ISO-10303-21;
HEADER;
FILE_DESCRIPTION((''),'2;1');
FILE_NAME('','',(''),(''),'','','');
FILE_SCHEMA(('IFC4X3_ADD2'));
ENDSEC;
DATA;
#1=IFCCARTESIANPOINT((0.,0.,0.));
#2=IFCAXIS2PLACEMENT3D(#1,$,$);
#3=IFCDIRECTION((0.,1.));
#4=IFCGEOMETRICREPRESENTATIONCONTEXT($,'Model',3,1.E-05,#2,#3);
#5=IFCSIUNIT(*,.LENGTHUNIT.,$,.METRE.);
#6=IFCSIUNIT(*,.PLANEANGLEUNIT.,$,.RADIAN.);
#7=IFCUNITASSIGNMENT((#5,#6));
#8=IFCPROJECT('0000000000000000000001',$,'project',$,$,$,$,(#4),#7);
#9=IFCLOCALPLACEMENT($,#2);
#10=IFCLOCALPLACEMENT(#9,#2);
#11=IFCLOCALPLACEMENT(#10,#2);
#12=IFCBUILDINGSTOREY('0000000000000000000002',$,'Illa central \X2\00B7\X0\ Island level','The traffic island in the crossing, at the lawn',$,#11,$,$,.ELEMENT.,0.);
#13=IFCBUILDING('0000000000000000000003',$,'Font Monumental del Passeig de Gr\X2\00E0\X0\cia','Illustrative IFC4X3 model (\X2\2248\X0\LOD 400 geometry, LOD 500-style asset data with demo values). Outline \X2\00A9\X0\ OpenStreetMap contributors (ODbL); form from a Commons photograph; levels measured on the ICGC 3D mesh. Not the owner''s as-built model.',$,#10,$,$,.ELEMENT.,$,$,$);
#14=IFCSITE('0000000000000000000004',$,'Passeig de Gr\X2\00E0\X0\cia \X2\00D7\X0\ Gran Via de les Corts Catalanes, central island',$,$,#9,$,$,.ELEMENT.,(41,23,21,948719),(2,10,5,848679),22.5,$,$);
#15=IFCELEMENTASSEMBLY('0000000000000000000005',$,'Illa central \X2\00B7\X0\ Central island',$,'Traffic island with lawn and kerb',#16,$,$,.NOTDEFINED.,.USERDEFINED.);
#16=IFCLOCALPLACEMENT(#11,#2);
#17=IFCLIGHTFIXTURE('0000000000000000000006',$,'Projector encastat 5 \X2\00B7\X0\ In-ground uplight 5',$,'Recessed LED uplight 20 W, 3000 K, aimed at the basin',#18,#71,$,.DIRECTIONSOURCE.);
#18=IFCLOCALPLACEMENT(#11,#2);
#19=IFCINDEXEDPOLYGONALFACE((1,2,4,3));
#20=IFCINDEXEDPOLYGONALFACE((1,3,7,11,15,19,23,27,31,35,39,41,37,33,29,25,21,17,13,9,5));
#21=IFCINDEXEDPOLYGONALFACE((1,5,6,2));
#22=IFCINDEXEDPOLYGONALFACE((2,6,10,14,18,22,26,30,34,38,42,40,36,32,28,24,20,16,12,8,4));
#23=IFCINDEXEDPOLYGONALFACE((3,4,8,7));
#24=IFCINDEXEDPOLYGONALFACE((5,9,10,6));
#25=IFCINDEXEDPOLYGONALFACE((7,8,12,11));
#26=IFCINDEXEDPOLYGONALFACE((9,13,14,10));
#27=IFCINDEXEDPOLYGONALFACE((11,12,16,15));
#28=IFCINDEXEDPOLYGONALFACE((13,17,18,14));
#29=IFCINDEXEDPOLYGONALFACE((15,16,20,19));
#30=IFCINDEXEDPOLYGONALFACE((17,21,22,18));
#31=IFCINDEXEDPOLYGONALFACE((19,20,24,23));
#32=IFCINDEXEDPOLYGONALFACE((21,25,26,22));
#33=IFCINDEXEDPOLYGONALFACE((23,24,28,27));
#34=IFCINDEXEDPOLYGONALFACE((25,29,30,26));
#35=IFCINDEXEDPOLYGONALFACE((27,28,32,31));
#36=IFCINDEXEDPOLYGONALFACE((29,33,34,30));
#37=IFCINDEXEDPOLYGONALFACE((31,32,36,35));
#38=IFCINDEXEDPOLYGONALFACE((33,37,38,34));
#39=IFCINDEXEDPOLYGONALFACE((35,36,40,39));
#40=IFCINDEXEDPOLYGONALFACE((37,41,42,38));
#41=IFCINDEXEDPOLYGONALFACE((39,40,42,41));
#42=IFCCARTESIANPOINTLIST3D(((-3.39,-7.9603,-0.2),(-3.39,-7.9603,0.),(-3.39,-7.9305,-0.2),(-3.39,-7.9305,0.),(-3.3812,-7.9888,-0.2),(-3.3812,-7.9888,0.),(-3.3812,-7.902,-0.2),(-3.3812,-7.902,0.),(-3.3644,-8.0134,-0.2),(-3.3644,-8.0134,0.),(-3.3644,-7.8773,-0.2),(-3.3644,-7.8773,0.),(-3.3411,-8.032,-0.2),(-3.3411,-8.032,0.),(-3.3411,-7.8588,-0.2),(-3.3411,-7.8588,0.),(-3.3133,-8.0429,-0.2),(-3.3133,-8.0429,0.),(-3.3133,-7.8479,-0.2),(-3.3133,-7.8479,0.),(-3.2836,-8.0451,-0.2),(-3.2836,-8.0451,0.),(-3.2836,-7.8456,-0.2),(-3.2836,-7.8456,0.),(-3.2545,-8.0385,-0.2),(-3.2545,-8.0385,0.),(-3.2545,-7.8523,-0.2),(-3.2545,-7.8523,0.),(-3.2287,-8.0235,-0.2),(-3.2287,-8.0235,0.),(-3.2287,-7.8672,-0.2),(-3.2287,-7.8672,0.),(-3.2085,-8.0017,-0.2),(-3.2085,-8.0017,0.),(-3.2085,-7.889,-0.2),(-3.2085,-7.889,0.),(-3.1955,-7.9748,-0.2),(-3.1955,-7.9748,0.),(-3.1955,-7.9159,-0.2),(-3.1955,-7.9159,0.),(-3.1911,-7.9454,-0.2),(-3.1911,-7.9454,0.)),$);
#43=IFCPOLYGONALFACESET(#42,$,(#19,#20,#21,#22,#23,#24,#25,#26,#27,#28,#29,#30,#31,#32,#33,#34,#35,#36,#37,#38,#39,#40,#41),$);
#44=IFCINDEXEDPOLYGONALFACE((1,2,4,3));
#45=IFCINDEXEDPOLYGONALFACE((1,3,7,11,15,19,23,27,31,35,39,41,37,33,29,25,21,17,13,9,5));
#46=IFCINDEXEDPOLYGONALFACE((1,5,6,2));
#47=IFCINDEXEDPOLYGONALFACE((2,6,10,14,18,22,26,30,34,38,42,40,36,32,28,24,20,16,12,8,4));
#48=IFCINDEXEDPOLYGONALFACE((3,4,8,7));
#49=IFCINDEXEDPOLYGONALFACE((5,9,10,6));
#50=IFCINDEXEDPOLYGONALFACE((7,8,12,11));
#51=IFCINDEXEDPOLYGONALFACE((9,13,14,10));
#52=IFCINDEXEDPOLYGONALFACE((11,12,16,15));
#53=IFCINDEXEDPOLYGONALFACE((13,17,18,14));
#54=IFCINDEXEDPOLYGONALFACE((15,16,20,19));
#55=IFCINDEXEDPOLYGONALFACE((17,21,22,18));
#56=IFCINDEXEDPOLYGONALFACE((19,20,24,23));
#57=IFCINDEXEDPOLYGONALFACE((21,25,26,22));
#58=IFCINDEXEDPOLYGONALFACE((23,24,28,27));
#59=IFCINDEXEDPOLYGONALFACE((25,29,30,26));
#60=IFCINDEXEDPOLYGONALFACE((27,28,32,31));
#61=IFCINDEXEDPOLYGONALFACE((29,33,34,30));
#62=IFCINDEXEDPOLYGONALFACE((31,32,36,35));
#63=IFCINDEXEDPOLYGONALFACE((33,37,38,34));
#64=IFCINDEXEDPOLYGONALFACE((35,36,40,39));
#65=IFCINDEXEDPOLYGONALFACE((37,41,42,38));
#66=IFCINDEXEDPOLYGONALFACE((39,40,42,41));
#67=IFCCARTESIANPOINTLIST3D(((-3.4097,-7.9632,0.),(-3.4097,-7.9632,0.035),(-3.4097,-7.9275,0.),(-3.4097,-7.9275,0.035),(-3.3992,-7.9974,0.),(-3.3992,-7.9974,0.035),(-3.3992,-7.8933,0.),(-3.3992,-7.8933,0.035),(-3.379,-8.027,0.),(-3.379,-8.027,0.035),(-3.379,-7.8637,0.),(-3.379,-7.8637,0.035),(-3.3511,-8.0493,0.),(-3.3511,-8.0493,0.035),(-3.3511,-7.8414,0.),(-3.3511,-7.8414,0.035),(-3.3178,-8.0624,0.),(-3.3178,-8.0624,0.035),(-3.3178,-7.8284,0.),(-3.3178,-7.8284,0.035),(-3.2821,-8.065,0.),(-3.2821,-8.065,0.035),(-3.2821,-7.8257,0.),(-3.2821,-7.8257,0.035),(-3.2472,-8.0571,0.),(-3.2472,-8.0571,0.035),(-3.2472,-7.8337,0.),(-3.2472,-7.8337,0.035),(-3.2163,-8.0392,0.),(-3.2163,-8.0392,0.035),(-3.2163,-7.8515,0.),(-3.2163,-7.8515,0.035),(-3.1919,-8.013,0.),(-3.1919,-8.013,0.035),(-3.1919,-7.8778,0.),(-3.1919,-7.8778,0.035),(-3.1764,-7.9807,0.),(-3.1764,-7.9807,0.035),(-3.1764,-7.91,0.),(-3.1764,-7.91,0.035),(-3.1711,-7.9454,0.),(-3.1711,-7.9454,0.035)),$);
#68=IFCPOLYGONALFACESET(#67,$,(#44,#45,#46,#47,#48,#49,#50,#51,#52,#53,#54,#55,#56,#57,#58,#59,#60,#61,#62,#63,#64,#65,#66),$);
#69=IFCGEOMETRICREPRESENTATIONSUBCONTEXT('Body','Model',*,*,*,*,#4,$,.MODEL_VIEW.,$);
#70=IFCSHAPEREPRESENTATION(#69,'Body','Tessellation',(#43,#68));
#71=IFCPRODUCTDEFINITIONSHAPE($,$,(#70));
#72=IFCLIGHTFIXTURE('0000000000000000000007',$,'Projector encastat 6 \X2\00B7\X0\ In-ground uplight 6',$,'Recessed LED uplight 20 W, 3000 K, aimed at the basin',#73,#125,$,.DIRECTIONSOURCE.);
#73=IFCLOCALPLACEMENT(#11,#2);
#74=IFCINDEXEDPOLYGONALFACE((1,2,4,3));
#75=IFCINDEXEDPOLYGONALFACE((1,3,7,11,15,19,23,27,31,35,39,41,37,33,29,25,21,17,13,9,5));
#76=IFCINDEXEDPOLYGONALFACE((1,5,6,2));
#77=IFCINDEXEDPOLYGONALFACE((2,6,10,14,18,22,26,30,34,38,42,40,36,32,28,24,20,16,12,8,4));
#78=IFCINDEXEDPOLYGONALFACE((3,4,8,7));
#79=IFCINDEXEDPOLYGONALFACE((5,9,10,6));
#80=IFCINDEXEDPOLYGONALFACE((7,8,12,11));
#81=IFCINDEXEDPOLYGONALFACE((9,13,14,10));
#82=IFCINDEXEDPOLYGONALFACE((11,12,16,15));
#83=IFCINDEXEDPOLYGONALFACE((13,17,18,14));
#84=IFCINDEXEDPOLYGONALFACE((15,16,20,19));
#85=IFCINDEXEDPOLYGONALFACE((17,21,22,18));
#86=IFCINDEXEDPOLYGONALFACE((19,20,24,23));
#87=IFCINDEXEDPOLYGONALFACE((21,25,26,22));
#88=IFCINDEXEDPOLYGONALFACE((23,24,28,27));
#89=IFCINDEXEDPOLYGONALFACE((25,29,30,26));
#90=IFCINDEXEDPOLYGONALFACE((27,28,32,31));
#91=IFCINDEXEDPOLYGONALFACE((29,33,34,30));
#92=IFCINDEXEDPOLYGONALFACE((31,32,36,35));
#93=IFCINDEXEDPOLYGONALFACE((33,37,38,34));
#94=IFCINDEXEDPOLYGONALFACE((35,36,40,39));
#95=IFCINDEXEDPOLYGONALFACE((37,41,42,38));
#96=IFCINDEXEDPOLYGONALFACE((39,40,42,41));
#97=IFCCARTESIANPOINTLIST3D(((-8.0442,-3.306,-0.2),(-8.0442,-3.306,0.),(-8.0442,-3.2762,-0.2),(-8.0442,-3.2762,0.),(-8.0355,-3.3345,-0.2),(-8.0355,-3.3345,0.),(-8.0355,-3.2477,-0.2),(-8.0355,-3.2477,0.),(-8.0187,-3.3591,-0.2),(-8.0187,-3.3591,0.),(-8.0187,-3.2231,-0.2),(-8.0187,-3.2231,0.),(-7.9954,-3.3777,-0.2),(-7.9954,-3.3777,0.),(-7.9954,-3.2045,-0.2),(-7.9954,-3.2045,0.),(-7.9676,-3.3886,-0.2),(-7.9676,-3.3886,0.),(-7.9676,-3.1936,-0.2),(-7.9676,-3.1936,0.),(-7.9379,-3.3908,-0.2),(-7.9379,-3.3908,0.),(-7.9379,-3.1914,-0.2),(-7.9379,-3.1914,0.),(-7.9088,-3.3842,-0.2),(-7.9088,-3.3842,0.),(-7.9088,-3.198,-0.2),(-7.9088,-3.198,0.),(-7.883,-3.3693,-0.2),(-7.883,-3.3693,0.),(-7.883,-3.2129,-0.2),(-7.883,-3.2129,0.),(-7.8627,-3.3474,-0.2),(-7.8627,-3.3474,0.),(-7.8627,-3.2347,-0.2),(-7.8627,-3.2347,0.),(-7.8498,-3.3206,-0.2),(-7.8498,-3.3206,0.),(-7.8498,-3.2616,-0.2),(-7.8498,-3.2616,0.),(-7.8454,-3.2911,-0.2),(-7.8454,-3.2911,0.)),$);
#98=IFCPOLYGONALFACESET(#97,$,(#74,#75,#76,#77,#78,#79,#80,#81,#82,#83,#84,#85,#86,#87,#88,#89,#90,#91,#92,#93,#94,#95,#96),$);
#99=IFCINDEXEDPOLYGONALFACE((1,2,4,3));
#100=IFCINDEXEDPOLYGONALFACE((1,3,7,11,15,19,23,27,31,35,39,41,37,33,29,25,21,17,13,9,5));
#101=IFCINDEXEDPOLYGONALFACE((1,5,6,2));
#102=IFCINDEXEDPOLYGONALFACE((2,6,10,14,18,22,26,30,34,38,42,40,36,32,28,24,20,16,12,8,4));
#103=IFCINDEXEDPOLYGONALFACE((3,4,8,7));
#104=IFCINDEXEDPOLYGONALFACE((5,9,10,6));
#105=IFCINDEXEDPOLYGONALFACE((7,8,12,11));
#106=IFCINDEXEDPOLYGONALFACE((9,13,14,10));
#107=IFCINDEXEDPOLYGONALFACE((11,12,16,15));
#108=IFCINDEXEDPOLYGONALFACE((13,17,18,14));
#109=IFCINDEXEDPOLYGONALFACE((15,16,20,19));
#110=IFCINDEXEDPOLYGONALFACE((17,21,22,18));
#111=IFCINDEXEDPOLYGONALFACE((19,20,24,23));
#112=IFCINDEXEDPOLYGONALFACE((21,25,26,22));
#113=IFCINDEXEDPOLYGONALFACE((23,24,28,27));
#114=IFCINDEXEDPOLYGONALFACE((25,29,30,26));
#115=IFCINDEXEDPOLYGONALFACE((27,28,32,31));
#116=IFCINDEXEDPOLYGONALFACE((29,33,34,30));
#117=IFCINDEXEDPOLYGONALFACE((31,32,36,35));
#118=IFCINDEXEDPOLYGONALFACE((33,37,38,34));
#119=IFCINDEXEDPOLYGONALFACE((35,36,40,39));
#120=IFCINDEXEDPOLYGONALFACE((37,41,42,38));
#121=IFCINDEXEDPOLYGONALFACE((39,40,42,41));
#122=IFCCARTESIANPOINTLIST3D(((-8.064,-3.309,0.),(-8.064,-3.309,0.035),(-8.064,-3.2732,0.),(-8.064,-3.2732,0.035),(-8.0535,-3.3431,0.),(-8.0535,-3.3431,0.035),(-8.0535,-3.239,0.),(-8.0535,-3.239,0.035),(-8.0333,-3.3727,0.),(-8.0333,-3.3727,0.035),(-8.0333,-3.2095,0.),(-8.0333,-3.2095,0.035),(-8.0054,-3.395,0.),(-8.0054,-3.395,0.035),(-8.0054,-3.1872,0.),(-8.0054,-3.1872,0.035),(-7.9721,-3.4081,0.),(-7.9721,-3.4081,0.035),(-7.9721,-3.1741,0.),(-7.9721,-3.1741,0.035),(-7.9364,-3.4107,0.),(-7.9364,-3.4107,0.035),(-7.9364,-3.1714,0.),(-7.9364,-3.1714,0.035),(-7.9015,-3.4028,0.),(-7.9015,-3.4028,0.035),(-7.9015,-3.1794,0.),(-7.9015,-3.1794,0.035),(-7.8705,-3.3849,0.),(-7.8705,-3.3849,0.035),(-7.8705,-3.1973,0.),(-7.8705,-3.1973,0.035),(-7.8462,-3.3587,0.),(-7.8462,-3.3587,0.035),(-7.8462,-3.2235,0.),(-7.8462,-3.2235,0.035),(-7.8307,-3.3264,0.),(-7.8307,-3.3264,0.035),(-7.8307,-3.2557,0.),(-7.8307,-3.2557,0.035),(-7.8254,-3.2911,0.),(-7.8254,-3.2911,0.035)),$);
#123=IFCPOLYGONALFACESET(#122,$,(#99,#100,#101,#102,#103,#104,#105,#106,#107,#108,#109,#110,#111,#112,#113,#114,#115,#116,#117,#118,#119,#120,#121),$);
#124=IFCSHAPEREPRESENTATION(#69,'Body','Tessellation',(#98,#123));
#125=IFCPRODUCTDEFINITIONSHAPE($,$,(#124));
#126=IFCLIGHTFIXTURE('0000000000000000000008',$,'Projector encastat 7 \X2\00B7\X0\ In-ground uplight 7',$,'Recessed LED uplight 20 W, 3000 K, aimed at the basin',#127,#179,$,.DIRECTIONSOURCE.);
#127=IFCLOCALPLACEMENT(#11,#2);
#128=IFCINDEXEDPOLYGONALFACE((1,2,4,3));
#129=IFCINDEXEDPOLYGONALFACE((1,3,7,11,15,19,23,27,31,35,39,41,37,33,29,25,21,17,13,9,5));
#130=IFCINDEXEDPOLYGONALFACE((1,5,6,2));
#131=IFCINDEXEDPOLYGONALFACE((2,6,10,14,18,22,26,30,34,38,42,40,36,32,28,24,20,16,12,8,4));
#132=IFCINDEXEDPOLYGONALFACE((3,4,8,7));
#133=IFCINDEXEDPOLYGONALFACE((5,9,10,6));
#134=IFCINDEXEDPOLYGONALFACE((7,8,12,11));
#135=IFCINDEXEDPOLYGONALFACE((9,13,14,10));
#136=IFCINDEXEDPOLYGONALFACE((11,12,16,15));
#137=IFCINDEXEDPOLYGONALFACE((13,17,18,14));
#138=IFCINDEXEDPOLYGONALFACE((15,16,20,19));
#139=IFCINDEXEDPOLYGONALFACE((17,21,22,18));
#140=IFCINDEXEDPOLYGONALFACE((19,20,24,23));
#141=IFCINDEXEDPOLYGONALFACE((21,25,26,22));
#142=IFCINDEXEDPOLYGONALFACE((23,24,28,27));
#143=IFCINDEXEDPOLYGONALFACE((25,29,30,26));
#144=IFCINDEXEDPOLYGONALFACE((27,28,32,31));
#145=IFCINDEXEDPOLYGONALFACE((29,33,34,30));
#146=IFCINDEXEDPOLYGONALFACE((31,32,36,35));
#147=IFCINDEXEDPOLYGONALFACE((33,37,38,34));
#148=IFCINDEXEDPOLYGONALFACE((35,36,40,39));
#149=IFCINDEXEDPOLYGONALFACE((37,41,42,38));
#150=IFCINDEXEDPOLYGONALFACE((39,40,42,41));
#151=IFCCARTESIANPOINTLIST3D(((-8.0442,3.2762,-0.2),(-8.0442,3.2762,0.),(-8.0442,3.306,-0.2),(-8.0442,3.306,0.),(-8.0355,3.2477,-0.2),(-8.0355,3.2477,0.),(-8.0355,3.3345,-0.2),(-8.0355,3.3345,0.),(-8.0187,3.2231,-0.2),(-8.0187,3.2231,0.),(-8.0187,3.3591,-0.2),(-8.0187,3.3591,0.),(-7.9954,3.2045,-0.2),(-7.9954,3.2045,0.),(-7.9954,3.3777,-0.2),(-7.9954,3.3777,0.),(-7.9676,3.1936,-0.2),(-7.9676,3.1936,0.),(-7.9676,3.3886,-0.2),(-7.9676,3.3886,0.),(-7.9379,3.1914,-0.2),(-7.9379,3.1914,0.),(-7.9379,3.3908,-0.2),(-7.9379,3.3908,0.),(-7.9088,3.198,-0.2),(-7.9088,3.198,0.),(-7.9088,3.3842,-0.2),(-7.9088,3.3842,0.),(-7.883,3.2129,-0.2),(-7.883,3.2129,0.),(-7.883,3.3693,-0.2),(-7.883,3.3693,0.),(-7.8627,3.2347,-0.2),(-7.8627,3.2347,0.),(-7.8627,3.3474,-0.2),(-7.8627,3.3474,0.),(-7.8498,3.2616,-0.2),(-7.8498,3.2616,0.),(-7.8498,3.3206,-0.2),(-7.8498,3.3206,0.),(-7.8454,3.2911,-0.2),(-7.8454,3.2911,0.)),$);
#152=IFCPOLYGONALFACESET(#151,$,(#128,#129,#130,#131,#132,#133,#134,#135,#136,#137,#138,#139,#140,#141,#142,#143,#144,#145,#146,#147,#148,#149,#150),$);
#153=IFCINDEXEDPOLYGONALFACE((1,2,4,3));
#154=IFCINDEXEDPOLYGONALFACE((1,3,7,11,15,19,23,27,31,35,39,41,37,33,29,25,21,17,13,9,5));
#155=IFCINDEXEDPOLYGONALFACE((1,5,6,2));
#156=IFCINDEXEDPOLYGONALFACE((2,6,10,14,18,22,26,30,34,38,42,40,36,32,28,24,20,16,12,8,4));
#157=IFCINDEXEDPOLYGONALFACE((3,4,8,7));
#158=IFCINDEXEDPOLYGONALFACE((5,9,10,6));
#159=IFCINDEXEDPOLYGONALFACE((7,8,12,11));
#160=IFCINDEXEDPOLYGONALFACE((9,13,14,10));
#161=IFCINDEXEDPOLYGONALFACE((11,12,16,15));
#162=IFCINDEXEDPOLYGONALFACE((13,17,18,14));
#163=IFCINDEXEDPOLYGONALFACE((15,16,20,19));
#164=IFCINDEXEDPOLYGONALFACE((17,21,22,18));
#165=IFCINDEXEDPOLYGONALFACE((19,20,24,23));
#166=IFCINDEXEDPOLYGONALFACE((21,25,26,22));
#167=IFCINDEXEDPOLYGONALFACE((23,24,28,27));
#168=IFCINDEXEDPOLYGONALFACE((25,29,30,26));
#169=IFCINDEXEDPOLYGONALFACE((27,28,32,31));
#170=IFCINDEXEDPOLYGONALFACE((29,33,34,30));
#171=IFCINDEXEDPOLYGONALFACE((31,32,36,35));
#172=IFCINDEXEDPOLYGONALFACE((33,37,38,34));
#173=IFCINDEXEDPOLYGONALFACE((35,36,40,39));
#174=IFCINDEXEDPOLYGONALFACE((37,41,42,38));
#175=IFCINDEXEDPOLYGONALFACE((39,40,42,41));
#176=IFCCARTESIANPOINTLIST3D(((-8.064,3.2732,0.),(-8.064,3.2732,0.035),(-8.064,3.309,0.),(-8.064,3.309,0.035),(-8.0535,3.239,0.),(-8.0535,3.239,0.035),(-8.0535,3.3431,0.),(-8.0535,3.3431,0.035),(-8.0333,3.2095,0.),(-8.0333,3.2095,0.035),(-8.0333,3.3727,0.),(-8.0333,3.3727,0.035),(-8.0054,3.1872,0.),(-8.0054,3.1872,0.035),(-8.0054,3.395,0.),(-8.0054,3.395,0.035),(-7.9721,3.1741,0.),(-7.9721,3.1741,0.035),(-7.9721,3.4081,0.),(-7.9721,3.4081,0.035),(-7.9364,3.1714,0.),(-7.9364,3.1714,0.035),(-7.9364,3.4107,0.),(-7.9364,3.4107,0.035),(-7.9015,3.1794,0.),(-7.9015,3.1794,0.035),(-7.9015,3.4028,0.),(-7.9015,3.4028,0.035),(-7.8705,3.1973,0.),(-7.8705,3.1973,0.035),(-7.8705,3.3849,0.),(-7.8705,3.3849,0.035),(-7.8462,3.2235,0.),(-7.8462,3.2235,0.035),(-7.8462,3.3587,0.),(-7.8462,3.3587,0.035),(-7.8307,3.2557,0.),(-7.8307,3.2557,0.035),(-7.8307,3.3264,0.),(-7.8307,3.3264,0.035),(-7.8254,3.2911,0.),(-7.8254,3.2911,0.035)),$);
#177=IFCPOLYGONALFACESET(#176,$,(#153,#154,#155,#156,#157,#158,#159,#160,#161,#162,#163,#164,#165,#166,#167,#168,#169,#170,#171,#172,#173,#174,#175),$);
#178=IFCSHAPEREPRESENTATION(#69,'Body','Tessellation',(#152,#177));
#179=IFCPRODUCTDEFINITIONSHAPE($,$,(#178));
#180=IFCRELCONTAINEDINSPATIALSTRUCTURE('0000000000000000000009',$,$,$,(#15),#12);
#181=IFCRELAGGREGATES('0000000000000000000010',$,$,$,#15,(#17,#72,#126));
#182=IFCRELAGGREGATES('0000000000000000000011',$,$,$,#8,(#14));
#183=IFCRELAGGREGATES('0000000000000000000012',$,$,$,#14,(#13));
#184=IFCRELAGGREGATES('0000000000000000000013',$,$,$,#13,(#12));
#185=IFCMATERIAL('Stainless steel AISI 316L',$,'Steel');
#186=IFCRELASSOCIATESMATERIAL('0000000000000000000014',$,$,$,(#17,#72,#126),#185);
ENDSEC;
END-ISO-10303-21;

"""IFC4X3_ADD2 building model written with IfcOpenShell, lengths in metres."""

from ifc_helpers import new_model, si_unit, direction, frame, origin, origin_2d_with_axis, place, context, subcontext, project, spatial, circle, extrude, material, element, aggregate, save


model = new_model("IFC4X3_ADD2")

# Units and contexts
model_context = context("Model", 3, precision=1e-05, world=origin(), true_north=direction((0.0, 1.0)))
body_context = subcontext(model_context, "Body", "Model", "MODEL_VIEW")
ifc_project = project(units=[si_unit("LENGTHUNIT", "METRE"), si_unit("PLANEANGLEUNIT", "RADIAN")], contexts=[model_context])

# Site, building, storey
site_placement = place(None, origin())
site = spatial("IfcSite", under=ifc_project, at=site_placement, Name="Passeig de Gràcia × Gran Via de les Corts Catalanes, central island", CompositionType="ELEMENT", RefLatitude=(41, 23, 21, 948719), RefLongitude=(2, 10, 5, 848679), RefElevation=22.5)
building_placement = place(site_placement, origin())
building = spatial("IfcBuilding", under=site, at=building_placement, Name="Font Monumental del Passeig de Gràcia", Description="Illustrative IFC4X3 model (≈LOD 400 geometry, LOD 500-style asset data with demo values). Outline © OpenStreetMap contributors (ODbL); form from a Commons photograph; levels measured on the ICGC 3D mesh. Not the owner's as-built model.", CompositionType="ELEMENT")
storey_placement = place(building_placement, origin())
storey = spatial("IfcBuildingStorey", under=building, at=storey_placement, Name="Illa central · Island level", Description="The traffic island in the crossing, at the lawn", CompositionType="ELEMENT", Elevation=0.0)

# Shared definitions
ifc_material_1 = material(Name="Stainless steel AISI 316L", Category="Steel")

# Element assembly, light fixtures
assembly_1_placement = place(building_placement, origin())
assembly_1 = element("IfcElementAssembly", 1, at=assembly_1_placement, inside=storey, Name="Illa central · Central island", ObjectType="Traffic island with lawn and kerb", AssemblyPlace="NOTDEFINED", PredefinedType="USERDEFINED")
light_fixture_1_placement = place(building_placement, origin())
light_fixture_1 = element("IfcLightFixture", 2, at=light_fixture_1_placement, material=ifc_material_1, Name="Projector encastat 5 · In-ground uplight 5", ObjectType="Recessed LED uplight 20 W, 3000 K, aimed at the basin", PredefinedType="DIRECTIONSOURCE", context=body_context, shape_type="SweptSolid", body=[
    extrude(circle(Radius=0.1, at=origin_2d_with_axis()), frame((-3.2911, -7.9454, -0.2)), (0.0, 0.0, 1.0), 0.2),
    extrude(circle(Radius=0.12, at=origin_2d_with_axis()), frame((-3.2911, -7.9454, 0.0)), (0.0, 0.0, 1.0), 0.035),
])
light_fixture_2_placement = place(building_placement, origin())
light_fixture_2 = element("IfcLightFixture", 3, at=light_fixture_2_placement, material=ifc_material_1, Name="Projector encastat 6 · In-ground uplight 6", ObjectType="Recessed LED uplight 20 W, 3000 K, aimed at the basin", PredefinedType="DIRECTIONSOURCE", context=body_context, shape_type="SweptSolid", body=[
    extrude(circle(Radius=0.1, at=origin_2d_with_axis()), frame((-7.9454, -3.2911, -0.2)), (0.0, 0.0, 1.0), 0.2),
    extrude(circle(Radius=0.12, at=origin_2d_with_axis()), frame((-7.9454, -3.2911, 0.0)), (0.0, 0.0, 1.0), 0.035),
])
light_fixture_3_placement = place(building_placement, origin())
light_fixture_3 = element("IfcLightFixture", 4, at=light_fixture_3_placement, material=ifc_material_1, Name="Projector encastat 7 · In-ground uplight 7", ObjectType="Recessed LED uplight 20 W, 3000 K, aimed at the basin", PredefinedType="DIRECTIONSOURCE", context=body_context, shape_type="SweptSolid", body=[
    extrude(circle(Radius=0.1, at=origin_2d_with_axis()), frame((-7.9454, 3.2911, -0.2)), (0.0, 0.0, 1.0), 0.2),
    extrude(circle(Radius=0.12, at=origin_2d_with_axis()), frame((-7.9454, 3.2911, 0.0)), (0.0, 0.0, 1.0), 0.035),
])

aggregate(assembly_1, [light_fixture_1, light_fixture_2, light_fixture_3])

save(model, "model.ifc")
